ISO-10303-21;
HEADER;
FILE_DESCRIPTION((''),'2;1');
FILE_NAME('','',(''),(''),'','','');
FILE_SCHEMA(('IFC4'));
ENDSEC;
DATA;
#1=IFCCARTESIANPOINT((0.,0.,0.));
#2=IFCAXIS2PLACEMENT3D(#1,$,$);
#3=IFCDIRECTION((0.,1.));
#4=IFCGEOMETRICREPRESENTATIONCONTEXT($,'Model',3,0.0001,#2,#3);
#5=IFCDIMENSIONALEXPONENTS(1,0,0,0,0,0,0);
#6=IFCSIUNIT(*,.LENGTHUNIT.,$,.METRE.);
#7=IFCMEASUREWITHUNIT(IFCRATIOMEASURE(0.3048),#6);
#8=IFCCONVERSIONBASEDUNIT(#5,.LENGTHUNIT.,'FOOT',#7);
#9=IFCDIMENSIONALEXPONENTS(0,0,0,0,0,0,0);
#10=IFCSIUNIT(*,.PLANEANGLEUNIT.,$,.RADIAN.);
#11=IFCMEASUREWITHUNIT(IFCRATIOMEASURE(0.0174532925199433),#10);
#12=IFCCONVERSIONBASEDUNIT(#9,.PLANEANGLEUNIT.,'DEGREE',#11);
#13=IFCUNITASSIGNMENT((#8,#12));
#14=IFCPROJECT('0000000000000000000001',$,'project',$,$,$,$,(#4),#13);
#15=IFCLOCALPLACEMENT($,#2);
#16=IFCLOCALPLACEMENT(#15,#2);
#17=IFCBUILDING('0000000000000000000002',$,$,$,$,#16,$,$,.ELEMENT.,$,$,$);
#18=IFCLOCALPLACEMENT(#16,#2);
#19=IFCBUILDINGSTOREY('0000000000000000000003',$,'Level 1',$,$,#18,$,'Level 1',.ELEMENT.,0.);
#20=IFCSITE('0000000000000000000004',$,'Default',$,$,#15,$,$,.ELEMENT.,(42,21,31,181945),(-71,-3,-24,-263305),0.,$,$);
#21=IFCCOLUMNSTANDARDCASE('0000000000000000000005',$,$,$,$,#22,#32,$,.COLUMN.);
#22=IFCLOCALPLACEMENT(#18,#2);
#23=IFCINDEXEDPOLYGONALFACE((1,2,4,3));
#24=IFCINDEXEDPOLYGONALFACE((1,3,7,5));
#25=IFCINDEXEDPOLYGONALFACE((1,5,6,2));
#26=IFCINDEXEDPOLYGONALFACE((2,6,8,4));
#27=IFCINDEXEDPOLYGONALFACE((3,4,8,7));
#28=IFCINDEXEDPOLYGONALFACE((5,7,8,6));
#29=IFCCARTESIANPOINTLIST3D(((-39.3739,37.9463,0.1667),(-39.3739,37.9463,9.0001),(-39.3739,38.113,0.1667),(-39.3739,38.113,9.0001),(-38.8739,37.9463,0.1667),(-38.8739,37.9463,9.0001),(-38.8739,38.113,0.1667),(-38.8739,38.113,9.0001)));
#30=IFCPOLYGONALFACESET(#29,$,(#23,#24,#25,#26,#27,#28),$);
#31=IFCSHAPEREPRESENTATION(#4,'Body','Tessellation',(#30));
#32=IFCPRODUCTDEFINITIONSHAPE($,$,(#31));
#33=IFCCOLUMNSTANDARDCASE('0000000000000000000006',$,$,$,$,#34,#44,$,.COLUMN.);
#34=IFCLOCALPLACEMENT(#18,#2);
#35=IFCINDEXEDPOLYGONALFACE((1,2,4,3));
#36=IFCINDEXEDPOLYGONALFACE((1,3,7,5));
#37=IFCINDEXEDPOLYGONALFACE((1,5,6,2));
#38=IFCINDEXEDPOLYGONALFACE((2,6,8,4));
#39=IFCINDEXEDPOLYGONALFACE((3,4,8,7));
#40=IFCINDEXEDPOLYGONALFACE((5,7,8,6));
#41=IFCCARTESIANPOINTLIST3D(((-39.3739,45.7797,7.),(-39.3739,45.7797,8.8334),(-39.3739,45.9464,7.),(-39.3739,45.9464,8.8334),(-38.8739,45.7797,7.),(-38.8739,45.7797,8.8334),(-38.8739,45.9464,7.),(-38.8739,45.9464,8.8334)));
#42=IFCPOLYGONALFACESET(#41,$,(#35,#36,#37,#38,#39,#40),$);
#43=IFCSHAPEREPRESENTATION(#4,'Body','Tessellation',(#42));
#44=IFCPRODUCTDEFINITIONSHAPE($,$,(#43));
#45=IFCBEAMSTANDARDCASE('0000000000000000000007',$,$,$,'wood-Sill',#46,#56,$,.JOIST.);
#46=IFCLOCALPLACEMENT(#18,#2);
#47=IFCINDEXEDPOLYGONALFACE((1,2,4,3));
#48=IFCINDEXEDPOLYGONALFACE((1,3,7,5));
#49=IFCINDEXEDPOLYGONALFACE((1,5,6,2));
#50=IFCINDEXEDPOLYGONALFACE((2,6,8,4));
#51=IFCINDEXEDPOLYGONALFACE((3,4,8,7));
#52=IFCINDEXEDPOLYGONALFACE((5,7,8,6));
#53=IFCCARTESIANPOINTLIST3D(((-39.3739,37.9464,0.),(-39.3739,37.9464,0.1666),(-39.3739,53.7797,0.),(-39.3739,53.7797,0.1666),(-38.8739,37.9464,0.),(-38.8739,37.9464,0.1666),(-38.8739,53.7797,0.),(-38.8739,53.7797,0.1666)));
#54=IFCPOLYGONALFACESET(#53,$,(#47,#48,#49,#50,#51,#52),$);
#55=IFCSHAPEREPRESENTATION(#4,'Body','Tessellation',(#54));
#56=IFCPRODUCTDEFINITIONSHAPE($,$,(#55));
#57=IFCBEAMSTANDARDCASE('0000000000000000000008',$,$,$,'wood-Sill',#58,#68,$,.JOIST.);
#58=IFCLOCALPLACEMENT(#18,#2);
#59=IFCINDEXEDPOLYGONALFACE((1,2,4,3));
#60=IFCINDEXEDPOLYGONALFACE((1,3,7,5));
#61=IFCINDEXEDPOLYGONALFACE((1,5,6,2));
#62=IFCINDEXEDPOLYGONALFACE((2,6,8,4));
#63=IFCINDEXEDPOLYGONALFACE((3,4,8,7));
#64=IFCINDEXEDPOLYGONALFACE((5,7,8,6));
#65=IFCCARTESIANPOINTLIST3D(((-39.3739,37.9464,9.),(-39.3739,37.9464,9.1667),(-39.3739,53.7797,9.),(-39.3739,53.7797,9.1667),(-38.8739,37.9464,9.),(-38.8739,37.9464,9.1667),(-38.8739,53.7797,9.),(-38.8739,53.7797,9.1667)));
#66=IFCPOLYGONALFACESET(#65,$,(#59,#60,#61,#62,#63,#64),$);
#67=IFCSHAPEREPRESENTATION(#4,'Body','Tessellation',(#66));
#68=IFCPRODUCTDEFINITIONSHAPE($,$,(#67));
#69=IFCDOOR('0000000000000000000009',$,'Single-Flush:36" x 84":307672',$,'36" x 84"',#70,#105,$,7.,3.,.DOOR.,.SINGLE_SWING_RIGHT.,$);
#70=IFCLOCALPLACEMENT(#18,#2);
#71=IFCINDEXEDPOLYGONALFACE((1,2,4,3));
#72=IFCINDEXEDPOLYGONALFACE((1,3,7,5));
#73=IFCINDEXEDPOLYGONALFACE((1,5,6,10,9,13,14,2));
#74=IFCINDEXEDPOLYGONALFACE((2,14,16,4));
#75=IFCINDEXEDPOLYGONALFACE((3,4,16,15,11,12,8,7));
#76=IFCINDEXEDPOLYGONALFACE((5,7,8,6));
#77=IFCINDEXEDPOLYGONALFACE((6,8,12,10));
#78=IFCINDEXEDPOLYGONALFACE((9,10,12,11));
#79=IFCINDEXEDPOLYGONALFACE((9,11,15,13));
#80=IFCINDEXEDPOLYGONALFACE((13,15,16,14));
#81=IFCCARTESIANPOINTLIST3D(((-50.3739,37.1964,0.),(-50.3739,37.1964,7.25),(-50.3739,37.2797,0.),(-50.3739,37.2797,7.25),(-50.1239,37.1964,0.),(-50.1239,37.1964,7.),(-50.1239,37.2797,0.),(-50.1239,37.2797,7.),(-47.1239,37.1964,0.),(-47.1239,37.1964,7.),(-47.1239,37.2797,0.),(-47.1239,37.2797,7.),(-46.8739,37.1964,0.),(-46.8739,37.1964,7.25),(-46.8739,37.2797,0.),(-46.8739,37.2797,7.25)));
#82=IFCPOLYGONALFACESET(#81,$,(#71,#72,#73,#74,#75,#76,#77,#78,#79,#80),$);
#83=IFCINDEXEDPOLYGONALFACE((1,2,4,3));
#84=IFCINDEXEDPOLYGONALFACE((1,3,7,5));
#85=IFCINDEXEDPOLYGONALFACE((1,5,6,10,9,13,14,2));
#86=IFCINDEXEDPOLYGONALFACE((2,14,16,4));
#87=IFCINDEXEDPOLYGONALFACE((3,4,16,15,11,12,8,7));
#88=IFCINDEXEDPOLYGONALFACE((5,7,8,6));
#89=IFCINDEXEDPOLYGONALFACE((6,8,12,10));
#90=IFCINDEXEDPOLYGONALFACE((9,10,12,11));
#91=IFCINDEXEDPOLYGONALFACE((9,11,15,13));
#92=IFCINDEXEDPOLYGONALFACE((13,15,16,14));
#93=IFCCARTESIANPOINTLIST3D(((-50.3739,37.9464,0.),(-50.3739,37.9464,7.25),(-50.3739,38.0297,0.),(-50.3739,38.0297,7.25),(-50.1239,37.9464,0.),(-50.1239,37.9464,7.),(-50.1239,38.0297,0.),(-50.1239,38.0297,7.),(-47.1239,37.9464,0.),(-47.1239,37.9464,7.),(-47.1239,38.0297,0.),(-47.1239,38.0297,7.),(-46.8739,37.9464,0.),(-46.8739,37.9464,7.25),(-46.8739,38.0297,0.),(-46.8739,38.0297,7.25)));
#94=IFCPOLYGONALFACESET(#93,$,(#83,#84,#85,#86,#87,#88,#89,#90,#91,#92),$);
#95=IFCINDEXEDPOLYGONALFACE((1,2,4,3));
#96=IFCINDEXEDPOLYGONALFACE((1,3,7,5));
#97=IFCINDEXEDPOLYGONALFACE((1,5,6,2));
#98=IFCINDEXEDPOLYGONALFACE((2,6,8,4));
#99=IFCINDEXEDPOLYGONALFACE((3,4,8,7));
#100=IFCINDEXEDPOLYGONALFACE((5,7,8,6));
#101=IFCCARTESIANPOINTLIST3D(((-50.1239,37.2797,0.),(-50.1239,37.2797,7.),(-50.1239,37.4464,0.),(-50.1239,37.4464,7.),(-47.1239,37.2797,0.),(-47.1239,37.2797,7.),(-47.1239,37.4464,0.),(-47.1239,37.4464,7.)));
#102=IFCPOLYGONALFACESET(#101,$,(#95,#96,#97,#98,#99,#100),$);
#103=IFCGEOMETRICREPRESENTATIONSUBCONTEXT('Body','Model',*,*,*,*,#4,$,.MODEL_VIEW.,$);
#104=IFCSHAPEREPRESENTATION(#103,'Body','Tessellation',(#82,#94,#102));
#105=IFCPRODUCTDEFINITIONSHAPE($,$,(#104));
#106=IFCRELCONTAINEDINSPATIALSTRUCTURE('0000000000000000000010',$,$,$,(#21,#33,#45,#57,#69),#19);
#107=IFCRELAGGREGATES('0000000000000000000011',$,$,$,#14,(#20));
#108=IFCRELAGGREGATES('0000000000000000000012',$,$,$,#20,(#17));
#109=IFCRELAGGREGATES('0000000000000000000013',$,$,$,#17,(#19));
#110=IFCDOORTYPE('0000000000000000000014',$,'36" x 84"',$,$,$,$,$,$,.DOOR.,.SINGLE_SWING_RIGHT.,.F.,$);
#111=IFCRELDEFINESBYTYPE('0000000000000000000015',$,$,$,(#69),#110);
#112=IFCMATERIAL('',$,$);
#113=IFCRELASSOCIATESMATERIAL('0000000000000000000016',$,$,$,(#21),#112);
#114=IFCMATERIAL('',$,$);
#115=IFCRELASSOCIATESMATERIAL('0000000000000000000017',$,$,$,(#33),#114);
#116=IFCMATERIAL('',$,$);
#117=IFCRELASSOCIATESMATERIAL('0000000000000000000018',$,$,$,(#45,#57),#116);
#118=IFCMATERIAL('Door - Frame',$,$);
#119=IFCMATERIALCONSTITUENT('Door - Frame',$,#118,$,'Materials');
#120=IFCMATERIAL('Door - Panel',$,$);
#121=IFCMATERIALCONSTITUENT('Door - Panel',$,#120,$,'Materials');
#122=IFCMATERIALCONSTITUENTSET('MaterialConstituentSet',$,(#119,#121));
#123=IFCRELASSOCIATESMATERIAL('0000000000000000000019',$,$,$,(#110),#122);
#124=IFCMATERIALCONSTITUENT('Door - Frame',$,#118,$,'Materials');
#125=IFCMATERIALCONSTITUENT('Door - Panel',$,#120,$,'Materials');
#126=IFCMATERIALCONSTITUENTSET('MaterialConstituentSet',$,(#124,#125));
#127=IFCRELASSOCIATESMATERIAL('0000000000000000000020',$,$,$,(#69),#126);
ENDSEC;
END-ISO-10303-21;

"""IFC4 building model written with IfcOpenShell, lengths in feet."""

from ifc_helpers import new_model, entity, si_unit, converted_unit, direction, frame, frame_2d, origin, origin_with_axes, place, context, subcontext, project, spatial, polyline, rectangle, outline, extrude, source, transform, mapped, material, constituent, constituent_set, type_object, type_shapes, element, save


model = new_model("IFC4")

# Units and contexts
model_context = context("Model", 3, precision=0.0001, world=origin(), true_north=direction((0.0, 1.0)))
body_context = subcontext(model_context, "Body", "Model", "MODEL_VIEW")
ifc_project = project(units=[converted_unit("LENGTHUNIT", "FOOT", entity("IfcRatioMeasure", 0.3048), si_unit("LENGTHUNIT", "METRE"), dimensions=[1, 0, 0, 0, 0, 0, 0]), converted_unit("PLANEANGLEUNIT", "DEGREE", entity("IfcRatioMeasure", 0.0174532925199433), si_unit("PLANEANGLEUNIT", "RADIAN"), dimensions=[0, 0, 0, 0, 0, 0, 0])], contexts=[model_context])

# Site, building, storey
site_placement = place(None, origin())
site = spatial("IfcSite", under=ifc_project, at=site_placement, Name="Default", CompositionType="ELEMENT", RefLatitude=(42, 21, 31, 181945), RefLongitude=(-71, -3, -24, -263305), RefElevation=0.0)
building_placement = place(site_placement, origin())
building = spatial("IfcBuilding", under=site, at=building_placement, CompositionType="ELEMENT")
storey_placement = place(building_placement, origin())
storey = spatial("IfcBuildingStorey", under=building, at=storey_placement, Name="Level 1", LongName="Level 1", CompositionType="ELEMENT", Elevation=0.0)

# Columns
ifc_material_1 = material(Name="")
placement_1 = place(storey_placement, frame((-39.1239, 37.9464, 0.0), z_axis=(0.0, 0.0, 1.0), x_axis=(0.0, 1.0, 0.0)))
for number, where, z_axis, x_axis in (
    (1, (0.0833, 0.0, 0.1667), (0.0, 0.0, 1.0), (1.0, 0.0, 0.0)),
):
    element("IfcColumnStandardCase", number, at=place(placement_1, frame(where, z_axis=z_axis, x_axis=x_axis)), inside=storey, material=ifc_material_1, PredefinedType="COLUMN", context=model_context, shape_type="SweptSolid", body=[
        extrude(rectangle(XDim=0.1667, YDim=0.5), origin(), (0.0, 0.0, 1.0), 8.8334),
    ])
ifc_material_2 = material(Name="")
for number, where, z_axis, x_axis in (
    (2, (7.9167, 0.0, 7.0), (0.0, 0.0, 1.0), (1.0, 0.0, 0.0)),
):
    element("IfcColumnStandardCase", number, at=place(placement_1, frame(where, z_axis=z_axis, x_axis=x_axis)), inside=storey, material=ifc_material_2, PredefinedType="COLUMN", context=model_context, shape_type="SweptSolid", body=[
        extrude(rectangle(XDim=0.1667, YDim=0.5), origin(), (0.0, 0.0, 1.0), 1.8334),
    ])

# Beams
placement_2 = place(storey_placement, frame((-21.2906, 37.6131, 0.0), z_axis=(0.0, 0.0, 1.0), x_axis=(-1.0, 0.0, 0.0)))
ifc_material_3 = material(Name="")
for number, where, z_axis, x_axis in (
    (3, (0.0, 0.0, 0.0833), (1.0, 0.0, 0.0), (0.0, 0.0, 1.0)),
    (4, (0.0, 0.0, 9.0834), (1.0, 0.0, 0.0), (0.0, 0.0, 1.0)),
):
    element("IfcBeamStandardCase", number, at=place(placement_1, frame(where, z_axis=z_axis, x_axis=x_axis)), inside=storey, material=ifc_material_3, ObjectType="wood-Sill", PredefinedType="JOIST", context=model_context, shape_type="SweptSolid", body=[
        extrude(rectangle(XDim=0.1667, YDim=0.5), origin_with_axes(), (0.0, 0.0, 1.0), 15.8333),
    ])

# Door
ifc_material_4 = material(Name="Door - Frame")
ifc_constituent_1 = constituent(ifc_material_4, Name="Door - Frame", Category="Materials")
ifc_material_5 = material(Name="Door - Panel")
ifc_constituent_2 = constituent(ifc_material_5, Name="Door - Panel", Category="Materials")
ifc_constituent_set_1 = constituent_set(constituents=[ifc_constituent_1, ifc_constituent_2], Name="MaterialConstituentSet")
ifc_constituent_3 = constituent(ifc_material_4, Name="Door - Frame", Category="Materials")
ifc_constituent_4 = constituent(ifc_material_5, Name="Door - Panel", Category="Materials")
ifc_constituent_set_2 = constituent_set(constituents=[ifc_constituent_3, ifc_constituent_4], Name="MaterialConstituentSet")
door_type = type_object("IfcDoorType", Name="36\" x 84\"", OperationType="SINGLE_SWING_RIGHT", ParameterTakesPrecedence=False, PredefinedType="DOOR", material=ifc_constituent_set_2)
shared_shape = source(origin(), body_context, "Body", "SweptSolid", [
    extrude(outline(polyline([(-1.75, -3.6875), (1.75, -3.6875), (1.75, 3.5625), (1.5, 3.5625), (1.5, -3.4375), (-1.5, -3.4375), (-1.5, 3.5625), (-1.75, 3.5625), (-1.75, -3.6875)])), frame((1.5, 0.6667, 3.5625), z_axis=(0.0, 1.0, 0.0), x_axis=(1.0, 0.0, 0.0)), (0.0, 0.0, 1.0), 0.0833),
    extrude(outline(polyline([(-3.6875, -1.75), (3.5625, -1.75), (3.5625, -1.5), (-3.4375, -1.5), (-3.4375, 1.5), (3.5625, 1.5), (3.5625, 1.75), (-3.6875, 1.75), (-3.6875, -1.75)])), frame((1.5, -0.0833, 3.5625), z_axis=(0.0, 1.0, 0.0), x_axis=(0.0, 0.0, -1.0)), (0.0, 0.0, 1.0), 0.0833),
    extrude(rectangle(XDim=0.1667, YDim=3.0, at=frame_2d((0.0, 0.0), x_axis=(1.0, 0.0))), frame((1.5, 0.5833, 0.0), z_axis=(0.0, 0.0, 1.0), x_axis=(0.0, 1.0, 0.0)), (0.0, 0.0, 1.0), 7.0),
])
type_shapes(door_type, [shared_shape])
placement_3 = place(placement_2, frame((25.8333, -0.3333, 0.0)))
door_placement = place(placement_3, origin())
element("IfcDoor", 5, at=door_placement, inside=storey, type_object=door_type, material=ifc_constituent_set_1, Name="Single-Flush:36\" x 84\":307672", ObjectType="36\" x 84\"", OperationType="SINGLE_SWING_RIGHT", OverallHeight=7.0, OverallWidth=3.0, PredefinedType="DOOR", context=body_context, shape_type="MappedRepresentation", body=[
    mapped(shared_shape, transform((0.0, 0.0, 0.0), scale=1.0)),
])

save(model, "model.ifc")
